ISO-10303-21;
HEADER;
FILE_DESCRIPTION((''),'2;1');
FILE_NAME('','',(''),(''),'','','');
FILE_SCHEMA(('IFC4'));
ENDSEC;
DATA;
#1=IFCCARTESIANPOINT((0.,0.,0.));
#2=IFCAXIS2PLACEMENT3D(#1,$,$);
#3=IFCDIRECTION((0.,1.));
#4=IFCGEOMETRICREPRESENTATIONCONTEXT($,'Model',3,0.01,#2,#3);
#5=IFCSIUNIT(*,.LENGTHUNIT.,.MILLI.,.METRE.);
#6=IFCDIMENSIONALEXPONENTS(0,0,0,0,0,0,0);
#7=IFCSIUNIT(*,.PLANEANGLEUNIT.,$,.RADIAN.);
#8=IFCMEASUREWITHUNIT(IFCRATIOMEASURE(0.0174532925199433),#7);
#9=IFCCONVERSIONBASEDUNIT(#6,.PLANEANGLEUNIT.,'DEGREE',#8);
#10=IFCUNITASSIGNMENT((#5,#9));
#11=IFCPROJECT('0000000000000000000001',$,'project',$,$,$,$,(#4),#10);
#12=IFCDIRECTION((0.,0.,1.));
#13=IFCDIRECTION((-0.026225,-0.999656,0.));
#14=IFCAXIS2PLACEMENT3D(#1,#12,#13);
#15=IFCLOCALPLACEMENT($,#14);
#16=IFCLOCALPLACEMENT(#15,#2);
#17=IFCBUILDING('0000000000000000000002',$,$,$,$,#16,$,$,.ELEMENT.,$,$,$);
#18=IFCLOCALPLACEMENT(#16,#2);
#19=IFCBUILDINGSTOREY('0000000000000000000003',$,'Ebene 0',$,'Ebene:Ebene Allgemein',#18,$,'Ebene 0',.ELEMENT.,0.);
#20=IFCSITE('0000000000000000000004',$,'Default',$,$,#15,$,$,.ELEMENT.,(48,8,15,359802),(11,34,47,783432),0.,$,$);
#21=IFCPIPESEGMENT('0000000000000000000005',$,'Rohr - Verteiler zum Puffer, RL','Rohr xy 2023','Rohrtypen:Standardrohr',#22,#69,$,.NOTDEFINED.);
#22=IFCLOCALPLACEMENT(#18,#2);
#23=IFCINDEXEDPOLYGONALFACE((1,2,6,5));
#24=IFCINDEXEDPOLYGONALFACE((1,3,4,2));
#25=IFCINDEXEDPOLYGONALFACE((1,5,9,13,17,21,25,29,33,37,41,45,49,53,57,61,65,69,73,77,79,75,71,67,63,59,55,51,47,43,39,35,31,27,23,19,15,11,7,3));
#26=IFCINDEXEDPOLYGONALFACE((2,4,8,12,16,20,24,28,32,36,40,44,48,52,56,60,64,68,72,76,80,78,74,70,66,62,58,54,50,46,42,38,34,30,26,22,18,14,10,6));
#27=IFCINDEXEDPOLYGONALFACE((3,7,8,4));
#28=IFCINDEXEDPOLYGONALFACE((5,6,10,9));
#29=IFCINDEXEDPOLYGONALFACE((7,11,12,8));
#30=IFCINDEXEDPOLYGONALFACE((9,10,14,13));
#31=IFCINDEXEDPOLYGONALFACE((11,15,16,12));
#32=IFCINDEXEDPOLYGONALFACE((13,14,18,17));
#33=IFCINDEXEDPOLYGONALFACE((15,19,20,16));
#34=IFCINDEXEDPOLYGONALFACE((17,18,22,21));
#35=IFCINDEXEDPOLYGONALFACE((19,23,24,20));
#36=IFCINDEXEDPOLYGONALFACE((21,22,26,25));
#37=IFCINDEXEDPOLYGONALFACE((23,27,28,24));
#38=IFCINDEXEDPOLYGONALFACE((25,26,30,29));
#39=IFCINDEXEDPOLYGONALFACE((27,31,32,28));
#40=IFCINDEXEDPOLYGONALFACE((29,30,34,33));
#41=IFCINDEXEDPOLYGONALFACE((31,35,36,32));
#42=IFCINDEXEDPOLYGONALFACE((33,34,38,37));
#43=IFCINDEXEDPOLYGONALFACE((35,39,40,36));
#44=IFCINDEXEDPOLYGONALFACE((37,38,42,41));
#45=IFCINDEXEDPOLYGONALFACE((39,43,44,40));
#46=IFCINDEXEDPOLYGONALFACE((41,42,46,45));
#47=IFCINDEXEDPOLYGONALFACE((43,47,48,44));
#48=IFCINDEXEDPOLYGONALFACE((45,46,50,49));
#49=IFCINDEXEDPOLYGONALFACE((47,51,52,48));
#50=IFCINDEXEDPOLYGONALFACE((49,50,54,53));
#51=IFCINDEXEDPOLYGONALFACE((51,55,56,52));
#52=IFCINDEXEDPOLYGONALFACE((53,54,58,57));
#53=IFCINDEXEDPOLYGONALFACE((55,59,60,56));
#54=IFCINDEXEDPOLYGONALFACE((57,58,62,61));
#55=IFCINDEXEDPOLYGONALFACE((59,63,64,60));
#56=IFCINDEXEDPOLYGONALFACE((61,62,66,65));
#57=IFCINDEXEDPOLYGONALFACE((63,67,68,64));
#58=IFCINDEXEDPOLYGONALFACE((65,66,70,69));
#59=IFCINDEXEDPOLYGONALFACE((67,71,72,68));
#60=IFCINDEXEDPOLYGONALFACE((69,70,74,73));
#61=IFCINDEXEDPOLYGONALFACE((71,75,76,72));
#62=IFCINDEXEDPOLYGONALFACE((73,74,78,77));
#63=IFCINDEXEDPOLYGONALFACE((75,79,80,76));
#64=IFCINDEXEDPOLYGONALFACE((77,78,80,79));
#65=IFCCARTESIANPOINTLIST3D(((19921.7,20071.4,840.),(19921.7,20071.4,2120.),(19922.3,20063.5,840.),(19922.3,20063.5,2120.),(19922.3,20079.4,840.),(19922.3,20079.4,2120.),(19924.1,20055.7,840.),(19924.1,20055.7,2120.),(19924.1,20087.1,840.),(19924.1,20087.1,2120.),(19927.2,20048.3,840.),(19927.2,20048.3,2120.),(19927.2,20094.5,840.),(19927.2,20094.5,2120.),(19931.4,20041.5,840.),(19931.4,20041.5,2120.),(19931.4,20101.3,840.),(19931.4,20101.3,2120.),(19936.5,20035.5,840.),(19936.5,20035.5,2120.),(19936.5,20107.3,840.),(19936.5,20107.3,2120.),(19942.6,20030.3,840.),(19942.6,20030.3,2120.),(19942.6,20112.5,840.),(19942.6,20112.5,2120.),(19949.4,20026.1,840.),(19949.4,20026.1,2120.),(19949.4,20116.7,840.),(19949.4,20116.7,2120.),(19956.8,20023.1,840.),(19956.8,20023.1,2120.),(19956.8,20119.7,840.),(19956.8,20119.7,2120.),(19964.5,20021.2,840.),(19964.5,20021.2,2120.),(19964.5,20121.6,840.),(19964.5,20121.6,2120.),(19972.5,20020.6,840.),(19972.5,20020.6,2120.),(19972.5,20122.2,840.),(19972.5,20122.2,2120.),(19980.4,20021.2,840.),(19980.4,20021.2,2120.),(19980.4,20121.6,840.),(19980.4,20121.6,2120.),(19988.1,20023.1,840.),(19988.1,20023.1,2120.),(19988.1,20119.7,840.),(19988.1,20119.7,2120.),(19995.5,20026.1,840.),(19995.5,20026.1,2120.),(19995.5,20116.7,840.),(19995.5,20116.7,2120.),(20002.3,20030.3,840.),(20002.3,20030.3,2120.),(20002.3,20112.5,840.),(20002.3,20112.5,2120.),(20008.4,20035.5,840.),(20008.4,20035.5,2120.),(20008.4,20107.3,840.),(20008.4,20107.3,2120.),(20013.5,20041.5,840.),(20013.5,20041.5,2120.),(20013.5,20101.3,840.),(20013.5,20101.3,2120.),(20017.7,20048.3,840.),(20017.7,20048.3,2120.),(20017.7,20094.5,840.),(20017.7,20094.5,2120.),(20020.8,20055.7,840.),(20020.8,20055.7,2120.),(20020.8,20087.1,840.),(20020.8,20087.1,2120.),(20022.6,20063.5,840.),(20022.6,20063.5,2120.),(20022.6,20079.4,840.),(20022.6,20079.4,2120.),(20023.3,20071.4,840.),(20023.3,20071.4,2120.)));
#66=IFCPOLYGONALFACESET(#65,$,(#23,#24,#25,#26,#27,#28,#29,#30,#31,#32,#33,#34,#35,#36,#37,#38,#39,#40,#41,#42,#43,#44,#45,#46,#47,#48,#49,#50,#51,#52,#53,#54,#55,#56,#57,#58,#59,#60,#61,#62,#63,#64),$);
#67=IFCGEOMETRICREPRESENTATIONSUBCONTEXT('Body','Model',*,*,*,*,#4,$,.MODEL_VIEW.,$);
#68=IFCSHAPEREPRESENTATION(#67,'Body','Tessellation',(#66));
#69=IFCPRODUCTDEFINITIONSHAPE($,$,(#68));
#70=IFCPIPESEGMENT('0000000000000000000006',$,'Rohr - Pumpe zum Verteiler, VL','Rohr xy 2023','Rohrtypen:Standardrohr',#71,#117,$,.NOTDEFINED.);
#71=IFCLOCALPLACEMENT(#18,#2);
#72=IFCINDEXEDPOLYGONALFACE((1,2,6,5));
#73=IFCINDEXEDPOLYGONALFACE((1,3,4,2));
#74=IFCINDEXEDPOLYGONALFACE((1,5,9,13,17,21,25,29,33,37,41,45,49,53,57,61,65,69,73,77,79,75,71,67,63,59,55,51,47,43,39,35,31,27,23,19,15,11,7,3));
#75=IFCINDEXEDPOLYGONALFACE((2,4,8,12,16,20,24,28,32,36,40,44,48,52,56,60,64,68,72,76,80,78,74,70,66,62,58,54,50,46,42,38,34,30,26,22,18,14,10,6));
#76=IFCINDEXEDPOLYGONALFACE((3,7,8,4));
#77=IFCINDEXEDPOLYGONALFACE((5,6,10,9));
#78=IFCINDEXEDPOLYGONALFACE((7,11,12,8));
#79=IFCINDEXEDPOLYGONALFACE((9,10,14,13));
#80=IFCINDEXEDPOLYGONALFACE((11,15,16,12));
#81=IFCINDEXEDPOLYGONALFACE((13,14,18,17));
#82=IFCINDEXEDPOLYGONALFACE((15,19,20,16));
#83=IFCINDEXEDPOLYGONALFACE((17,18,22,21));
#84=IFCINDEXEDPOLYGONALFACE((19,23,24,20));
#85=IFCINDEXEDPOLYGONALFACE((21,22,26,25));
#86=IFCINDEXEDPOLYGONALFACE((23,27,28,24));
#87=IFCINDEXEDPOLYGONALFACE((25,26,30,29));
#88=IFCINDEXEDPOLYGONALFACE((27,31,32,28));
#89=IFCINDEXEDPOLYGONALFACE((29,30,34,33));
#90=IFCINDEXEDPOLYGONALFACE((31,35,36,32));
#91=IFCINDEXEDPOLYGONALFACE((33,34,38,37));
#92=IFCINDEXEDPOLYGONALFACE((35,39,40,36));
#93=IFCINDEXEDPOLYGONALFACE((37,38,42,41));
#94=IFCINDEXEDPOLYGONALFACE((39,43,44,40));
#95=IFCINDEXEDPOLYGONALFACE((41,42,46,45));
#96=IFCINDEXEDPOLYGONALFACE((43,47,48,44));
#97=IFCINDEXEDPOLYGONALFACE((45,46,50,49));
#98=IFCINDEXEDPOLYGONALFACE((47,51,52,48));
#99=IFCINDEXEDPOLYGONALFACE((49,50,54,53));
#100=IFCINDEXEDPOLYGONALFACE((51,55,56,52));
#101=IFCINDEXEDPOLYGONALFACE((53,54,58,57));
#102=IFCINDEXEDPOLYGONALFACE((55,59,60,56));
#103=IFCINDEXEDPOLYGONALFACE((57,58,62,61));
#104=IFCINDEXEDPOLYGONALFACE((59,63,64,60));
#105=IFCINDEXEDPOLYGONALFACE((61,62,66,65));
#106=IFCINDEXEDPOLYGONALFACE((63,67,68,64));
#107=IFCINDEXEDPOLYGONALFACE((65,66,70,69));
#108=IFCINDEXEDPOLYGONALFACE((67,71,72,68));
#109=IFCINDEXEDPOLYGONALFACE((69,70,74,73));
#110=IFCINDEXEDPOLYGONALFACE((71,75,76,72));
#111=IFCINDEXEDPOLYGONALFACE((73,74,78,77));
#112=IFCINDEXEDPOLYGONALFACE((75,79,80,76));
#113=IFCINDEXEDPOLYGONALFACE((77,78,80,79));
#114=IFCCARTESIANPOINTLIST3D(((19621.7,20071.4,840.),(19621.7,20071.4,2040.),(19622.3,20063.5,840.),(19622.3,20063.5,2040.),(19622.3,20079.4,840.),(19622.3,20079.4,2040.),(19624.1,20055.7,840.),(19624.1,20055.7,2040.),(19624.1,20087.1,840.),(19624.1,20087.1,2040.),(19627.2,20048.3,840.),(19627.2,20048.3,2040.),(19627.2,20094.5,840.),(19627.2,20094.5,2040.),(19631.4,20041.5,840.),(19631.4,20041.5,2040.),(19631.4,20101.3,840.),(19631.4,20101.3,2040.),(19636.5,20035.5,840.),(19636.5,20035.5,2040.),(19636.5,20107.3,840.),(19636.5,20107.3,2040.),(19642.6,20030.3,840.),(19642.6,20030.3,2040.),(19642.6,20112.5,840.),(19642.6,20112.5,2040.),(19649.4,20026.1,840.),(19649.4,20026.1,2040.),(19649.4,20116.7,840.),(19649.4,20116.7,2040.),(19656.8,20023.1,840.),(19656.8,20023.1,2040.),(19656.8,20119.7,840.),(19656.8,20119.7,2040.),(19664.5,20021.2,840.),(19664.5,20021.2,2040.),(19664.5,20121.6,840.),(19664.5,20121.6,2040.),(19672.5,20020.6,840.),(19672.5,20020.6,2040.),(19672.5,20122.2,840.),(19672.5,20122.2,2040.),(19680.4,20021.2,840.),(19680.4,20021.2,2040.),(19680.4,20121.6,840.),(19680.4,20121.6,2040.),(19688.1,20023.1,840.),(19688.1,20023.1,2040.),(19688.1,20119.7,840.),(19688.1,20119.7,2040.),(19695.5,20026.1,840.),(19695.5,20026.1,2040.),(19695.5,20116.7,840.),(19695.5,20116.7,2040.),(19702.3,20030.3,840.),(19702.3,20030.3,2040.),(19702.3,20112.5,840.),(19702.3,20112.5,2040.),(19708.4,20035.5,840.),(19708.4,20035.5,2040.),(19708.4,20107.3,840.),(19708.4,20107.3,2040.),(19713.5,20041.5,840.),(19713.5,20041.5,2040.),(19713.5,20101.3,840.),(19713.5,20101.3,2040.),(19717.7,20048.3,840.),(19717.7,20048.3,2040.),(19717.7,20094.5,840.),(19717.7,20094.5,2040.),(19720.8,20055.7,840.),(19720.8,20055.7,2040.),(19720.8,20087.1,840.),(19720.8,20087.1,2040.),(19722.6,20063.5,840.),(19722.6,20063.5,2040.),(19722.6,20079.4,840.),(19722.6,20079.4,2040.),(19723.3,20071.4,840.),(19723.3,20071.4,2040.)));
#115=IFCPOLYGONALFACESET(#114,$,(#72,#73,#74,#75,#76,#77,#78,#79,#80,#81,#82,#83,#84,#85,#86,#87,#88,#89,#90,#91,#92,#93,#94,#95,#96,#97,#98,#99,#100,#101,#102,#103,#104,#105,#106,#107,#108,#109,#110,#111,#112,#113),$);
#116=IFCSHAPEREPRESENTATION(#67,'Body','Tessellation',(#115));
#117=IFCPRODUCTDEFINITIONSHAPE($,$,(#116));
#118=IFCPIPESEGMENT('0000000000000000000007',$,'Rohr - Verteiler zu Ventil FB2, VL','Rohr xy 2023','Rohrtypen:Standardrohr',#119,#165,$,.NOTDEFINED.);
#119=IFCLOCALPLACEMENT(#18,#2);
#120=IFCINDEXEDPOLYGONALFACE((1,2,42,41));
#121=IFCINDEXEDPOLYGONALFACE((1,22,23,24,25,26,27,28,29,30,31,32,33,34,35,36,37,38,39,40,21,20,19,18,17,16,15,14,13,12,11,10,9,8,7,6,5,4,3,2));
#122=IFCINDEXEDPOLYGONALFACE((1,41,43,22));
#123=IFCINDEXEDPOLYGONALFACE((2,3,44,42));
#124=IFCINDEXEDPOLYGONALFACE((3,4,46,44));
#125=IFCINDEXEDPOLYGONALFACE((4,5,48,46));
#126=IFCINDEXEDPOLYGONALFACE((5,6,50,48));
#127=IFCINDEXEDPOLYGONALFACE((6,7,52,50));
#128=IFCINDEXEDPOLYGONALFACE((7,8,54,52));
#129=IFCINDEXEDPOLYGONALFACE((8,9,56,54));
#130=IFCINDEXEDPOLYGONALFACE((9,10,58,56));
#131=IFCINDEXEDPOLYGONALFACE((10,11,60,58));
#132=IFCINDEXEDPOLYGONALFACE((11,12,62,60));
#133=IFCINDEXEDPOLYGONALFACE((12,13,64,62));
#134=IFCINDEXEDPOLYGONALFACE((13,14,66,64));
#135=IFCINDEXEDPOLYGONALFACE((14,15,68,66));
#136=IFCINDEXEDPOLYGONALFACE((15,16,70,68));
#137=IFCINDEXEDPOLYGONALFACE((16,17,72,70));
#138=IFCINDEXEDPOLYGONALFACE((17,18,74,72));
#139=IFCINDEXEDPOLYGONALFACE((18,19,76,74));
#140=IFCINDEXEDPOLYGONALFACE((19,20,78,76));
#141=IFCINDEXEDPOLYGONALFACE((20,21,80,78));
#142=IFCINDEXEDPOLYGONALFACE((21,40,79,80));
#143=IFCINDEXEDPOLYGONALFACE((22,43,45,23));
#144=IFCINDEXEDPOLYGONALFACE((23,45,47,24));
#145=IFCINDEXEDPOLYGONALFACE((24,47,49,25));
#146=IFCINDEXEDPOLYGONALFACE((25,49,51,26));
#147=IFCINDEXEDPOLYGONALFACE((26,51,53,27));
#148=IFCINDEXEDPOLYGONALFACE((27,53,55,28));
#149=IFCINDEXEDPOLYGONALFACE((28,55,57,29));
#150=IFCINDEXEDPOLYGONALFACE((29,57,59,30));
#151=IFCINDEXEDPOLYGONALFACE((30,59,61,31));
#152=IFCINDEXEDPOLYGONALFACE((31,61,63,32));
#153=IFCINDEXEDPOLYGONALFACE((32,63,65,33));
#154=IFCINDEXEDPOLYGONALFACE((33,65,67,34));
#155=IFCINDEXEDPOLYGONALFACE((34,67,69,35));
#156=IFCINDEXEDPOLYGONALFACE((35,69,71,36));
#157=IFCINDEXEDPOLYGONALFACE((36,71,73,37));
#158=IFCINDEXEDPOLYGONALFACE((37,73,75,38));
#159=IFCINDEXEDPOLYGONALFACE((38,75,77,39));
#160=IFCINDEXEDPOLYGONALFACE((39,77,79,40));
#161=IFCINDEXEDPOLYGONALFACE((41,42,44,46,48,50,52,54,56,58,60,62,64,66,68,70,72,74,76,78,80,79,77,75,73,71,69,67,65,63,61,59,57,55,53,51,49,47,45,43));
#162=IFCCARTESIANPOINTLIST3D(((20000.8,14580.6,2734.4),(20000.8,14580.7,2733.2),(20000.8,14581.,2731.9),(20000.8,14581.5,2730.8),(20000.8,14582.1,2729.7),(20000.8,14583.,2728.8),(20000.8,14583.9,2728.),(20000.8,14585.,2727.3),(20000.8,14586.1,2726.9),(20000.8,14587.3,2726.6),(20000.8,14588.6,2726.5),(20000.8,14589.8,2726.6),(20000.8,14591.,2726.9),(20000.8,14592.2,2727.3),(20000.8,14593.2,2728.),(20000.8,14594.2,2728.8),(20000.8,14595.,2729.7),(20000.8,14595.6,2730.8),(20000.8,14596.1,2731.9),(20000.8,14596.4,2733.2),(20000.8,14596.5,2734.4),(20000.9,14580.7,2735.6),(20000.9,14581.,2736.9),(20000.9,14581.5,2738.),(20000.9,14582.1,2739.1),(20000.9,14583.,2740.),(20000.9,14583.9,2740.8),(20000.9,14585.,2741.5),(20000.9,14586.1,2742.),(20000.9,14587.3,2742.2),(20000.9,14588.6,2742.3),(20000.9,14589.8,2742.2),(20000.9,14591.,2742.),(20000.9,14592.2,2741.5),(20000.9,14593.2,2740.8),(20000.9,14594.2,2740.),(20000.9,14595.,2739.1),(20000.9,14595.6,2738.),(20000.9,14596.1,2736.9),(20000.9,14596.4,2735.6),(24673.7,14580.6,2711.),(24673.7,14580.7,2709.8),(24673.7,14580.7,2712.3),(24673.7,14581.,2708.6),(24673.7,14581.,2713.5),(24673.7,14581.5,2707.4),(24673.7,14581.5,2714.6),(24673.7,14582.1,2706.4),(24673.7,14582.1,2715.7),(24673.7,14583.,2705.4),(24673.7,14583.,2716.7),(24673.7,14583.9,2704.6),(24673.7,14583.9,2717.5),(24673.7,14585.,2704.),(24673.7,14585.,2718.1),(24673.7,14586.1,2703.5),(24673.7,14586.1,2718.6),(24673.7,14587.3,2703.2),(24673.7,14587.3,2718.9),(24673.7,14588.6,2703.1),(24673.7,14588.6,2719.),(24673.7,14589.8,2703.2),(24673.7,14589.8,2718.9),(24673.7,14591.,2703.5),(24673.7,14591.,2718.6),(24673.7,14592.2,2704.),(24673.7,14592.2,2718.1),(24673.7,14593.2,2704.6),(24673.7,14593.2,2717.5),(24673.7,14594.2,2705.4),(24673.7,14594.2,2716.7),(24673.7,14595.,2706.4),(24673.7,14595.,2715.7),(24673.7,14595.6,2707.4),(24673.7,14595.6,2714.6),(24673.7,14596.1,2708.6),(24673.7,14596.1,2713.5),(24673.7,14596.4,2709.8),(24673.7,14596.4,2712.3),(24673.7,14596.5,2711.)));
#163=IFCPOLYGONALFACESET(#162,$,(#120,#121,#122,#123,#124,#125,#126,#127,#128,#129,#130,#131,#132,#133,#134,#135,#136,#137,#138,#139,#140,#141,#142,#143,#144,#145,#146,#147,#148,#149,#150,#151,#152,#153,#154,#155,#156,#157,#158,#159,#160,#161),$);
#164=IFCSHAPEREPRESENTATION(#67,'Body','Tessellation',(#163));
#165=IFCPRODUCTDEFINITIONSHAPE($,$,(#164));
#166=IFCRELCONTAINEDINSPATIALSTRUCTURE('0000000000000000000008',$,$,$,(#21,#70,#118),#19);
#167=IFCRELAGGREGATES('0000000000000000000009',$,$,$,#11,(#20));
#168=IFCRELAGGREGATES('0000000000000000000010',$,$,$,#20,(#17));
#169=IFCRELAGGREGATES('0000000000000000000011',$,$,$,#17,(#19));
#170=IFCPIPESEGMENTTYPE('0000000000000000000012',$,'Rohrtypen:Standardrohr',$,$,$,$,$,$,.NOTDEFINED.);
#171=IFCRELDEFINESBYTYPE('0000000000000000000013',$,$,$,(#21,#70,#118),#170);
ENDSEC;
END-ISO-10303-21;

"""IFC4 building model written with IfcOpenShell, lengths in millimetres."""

from ifc_helpers import new_model, entity, si_unit, converted_unit, direction, frame, origin, place, context, subcontext, project, spatial, indexed_curve, outline, extrude, type_object, element, save


model = new_model("IFC4")

# Units and contexts
model_context = context("Model", 3, precision=0.01, world=origin(), true_north=direction((0.0, 1.0)))
body_context = subcontext(model_context, "Body", "Model", "MODEL_VIEW")
ifc_project = project(units=[si_unit("LENGTHUNIT", "METRE", prefix="MILLI"), converted_unit("PLANEANGLEUNIT", "DEGREE", entity("IfcRatioMeasure", 0.0174532925199433), si_unit("PLANEANGLEUNIT", "RADIAN"), dimensions=[0, 0, 0, 0, 0, 0, 0])], contexts=[model_context])

# Site, building, storey
site_placement = place(None, frame((0.0, 0.0, 0.0), z_axis=(0.0, 0.0, 1.0), x_axis=(-0.026225, -0.999656, 0.0)))
site = spatial("IfcSite", under=ifc_project, at=site_placement, Name="Default", CompositionType="ELEMENT", RefLatitude=(48, 8, 15, 359802), RefLongitude=(11, 34, 47, 783432), RefElevation=0.0)
building_placement = place(site_placement, origin())
building = spatial("IfcBuilding", under=site, at=building_placement, CompositionType="ELEMENT")
storey_placement = place(building_placement, origin())
storey = spatial("IfcBuildingStorey", under=building, at=storey_placement, Name="Ebene 0", ObjectType="Ebene:Ebene Allgemein", LongName="Ebene 0", CompositionType="ELEMENT", Elevation=0.0)

# Pipe segments
pipe_segment_type = type_object("IfcPipeSegmentType", Name="Rohrtypen:Standardrohr", PredefinedType="NOTDEFINED")
pipe_segment_1_placement = place(storey_placement, origin())
element("IfcPipeSegment", 1, at=pipe_segment_1_placement, inside=storey, type_object=pipe_segment_type, Name="Rohr - Verteiler zum Puffer, RL", Description="Rohr xy 2023", ObjectType="Rohrtypen:Standardrohr", PredefinedType="NOTDEFINED", context=body_context, shape_type="SweptSolid", body=[
    extrude(outline(indexed_curve([(50.8, 0.0), (50.2, 7.9), (48.3, 15.7), (45.3, 23.1), (41.1, 29.9), (35.9, 35.9), (29.9, 41.1), (23.1, 45.3), (15.7, 48.3), (7.9, 50.2), (0.0, 50.8), (-7.9, 50.2), (-15.7, 48.3), (-23.1, 45.3), (-29.9, 41.1), (-35.9, 35.9), (-41.1, 29.9), (-45.3, 23.1), (-48.3, 15.7), (-50.2, 7.9), (-50.8, 0.0), (-50.2, -7.9), (-48.3, -15.7), (-45.3, -23.1), (-41.1, -29.9), (-35.9, -35.9), (-29.9, -41.1), (-23.1, -45.3), (-15.7, -48.3), (-7.9, -50.2), (0.0, -50.8), (7.9, -50.2), (15.7, -48.3), (23.1, -45.3), (29.9, -41.1), (35.9, -35.9), (41.1, -29.9), (45.3, -23.1), (48.3, -15.7), (50.2, -7.9), (50.8, 0.0)], self_intersect=False)), frame((19972.5, 20071.4, 840.0), z_axis=(0.0, 0.0, 1.0), x_axis=(-1.0, 0.0, 0.0)), (0.0, 0.0, 1.0), 1280.0),
])
pipe_segment_2_placement = place(storey_placement, origin())
element("IfcPipeSegment", 2, at=pipe_segment_2_placement, inside=storey, type_object=pipe_segment_type, Name="Rohr - Pumpe zum Verteiler, VL", Description="Rohr xy 2023", ObjectType="Rohrtypen:Standardrohr", PredefinedType="NOTDEFINED", context=body_context, shape_type="SweptSolid", body=[
    extrude(outline(indexed_curve([(50.8, 0.0), (50.2, 7.9), (48.3, 15.7), (45.3, 23.1), (41.1, 29.9), (35.9, 35.9), (29.9, 41.1), (23.1, 45.3), (15.7, 48.3), (7.9, 50.2), (0.0, 50.8), (-7.9, 50.2), (-15.7, 48.3), (-23.1, 45.3), (-29.9, 41.1), (-35.9, 35.9), (-41.1, 29.9), (-45.3, 23.1), (-48.3, 15.7), (-50.2, 7.9), (-50.8, 0.0), (-50.2, -7.9), (-48.3, -15.7), (-45.3, -23.1), (-41.1, -29.9), (-35.9, -35.9), (-29.9, -41.1), (-23.1, -45.3), (-15.7, -48.3), (-7.9, -50.2), (0.0, -50.8), (7.9, -50.2), (15.7, -48.3), (23.1, -45.3), (29.9, -41.1), (35.9, -35.9), (41.1, -29.9), (45.3, -23.1), (48.3, -15.7), (50.2, -7.9), (50.8, 0.0)], self_intersect=False)), frame((19672.5, 20071.4, 840.0), z_axis=(0.0, 0.0, 1.0), x_axis=(-1.0, 0.0, 0.0)), (0.0, 0.0, 1.0), 1200.0),
])
pipe_segment_3_placement = place(storey_placement, origin())
element("IfcPipeSegment", 3, at=pipe_segment_3_placement, inside=storey, type_object=pipe_segment_type, Name="Rohr - Verteiler zu Ventil FB2, VL", Description="Rohr xy 2023", ObjectType="Rohrtypen:Standardrohr", PredefinedType="NOTDEFINED", context=body_context, shape_type="SweptSolid", body=[
    extrude(outline(indexed_curve([(7.9, 0.0), (7.8, 1.2), (7.6, 2.5), (7.1, 3.6), (6.4, 4.7), (5.6, 5.6), (4.7, 6.4), (3.6, 7.1), (2.5, 7.6), (1.2, 7.8), (0.0, 7.9), (-1.2, 7.8), (-2.5, 7.6), (-3.6, 7.1), (-4.7, 6.4), (-5.6, 5.6), (-6.4, 4.7), (-7.1, 3.6), (-7.6, 2.5), (-7.8, 1.2), (-7.9, 0.0), (-7.8, -1.2), (-7.6, -2.5), (-7.1, -3.6), (-6.4, -4.7), (-5.6, -5.6), (-4.7, -6.4), (-3.6, -7.1), (-2.5, -7.6), (-1.2, -7.8), (0.0, -7.9), (1.2, -7.8), (2.5, -7.6), (3.6, -7.1), (4.7, -6.4), (5.6, -5.6), (6.4, -4.7), (7.1, -3.6), (7.6, -2.5), (7.8, -1.2), (7.9, 0.0)], self_intersect=False)), frame((24673.7, 14588.6, 2711.0), z_axis=(-0.999988, 0.0, 0.005), x_axis=(0.0, 1.0, 0.0)), (0.0, 0.0, 1.0), 4672.9),
])

save(model, "model.ifc")
